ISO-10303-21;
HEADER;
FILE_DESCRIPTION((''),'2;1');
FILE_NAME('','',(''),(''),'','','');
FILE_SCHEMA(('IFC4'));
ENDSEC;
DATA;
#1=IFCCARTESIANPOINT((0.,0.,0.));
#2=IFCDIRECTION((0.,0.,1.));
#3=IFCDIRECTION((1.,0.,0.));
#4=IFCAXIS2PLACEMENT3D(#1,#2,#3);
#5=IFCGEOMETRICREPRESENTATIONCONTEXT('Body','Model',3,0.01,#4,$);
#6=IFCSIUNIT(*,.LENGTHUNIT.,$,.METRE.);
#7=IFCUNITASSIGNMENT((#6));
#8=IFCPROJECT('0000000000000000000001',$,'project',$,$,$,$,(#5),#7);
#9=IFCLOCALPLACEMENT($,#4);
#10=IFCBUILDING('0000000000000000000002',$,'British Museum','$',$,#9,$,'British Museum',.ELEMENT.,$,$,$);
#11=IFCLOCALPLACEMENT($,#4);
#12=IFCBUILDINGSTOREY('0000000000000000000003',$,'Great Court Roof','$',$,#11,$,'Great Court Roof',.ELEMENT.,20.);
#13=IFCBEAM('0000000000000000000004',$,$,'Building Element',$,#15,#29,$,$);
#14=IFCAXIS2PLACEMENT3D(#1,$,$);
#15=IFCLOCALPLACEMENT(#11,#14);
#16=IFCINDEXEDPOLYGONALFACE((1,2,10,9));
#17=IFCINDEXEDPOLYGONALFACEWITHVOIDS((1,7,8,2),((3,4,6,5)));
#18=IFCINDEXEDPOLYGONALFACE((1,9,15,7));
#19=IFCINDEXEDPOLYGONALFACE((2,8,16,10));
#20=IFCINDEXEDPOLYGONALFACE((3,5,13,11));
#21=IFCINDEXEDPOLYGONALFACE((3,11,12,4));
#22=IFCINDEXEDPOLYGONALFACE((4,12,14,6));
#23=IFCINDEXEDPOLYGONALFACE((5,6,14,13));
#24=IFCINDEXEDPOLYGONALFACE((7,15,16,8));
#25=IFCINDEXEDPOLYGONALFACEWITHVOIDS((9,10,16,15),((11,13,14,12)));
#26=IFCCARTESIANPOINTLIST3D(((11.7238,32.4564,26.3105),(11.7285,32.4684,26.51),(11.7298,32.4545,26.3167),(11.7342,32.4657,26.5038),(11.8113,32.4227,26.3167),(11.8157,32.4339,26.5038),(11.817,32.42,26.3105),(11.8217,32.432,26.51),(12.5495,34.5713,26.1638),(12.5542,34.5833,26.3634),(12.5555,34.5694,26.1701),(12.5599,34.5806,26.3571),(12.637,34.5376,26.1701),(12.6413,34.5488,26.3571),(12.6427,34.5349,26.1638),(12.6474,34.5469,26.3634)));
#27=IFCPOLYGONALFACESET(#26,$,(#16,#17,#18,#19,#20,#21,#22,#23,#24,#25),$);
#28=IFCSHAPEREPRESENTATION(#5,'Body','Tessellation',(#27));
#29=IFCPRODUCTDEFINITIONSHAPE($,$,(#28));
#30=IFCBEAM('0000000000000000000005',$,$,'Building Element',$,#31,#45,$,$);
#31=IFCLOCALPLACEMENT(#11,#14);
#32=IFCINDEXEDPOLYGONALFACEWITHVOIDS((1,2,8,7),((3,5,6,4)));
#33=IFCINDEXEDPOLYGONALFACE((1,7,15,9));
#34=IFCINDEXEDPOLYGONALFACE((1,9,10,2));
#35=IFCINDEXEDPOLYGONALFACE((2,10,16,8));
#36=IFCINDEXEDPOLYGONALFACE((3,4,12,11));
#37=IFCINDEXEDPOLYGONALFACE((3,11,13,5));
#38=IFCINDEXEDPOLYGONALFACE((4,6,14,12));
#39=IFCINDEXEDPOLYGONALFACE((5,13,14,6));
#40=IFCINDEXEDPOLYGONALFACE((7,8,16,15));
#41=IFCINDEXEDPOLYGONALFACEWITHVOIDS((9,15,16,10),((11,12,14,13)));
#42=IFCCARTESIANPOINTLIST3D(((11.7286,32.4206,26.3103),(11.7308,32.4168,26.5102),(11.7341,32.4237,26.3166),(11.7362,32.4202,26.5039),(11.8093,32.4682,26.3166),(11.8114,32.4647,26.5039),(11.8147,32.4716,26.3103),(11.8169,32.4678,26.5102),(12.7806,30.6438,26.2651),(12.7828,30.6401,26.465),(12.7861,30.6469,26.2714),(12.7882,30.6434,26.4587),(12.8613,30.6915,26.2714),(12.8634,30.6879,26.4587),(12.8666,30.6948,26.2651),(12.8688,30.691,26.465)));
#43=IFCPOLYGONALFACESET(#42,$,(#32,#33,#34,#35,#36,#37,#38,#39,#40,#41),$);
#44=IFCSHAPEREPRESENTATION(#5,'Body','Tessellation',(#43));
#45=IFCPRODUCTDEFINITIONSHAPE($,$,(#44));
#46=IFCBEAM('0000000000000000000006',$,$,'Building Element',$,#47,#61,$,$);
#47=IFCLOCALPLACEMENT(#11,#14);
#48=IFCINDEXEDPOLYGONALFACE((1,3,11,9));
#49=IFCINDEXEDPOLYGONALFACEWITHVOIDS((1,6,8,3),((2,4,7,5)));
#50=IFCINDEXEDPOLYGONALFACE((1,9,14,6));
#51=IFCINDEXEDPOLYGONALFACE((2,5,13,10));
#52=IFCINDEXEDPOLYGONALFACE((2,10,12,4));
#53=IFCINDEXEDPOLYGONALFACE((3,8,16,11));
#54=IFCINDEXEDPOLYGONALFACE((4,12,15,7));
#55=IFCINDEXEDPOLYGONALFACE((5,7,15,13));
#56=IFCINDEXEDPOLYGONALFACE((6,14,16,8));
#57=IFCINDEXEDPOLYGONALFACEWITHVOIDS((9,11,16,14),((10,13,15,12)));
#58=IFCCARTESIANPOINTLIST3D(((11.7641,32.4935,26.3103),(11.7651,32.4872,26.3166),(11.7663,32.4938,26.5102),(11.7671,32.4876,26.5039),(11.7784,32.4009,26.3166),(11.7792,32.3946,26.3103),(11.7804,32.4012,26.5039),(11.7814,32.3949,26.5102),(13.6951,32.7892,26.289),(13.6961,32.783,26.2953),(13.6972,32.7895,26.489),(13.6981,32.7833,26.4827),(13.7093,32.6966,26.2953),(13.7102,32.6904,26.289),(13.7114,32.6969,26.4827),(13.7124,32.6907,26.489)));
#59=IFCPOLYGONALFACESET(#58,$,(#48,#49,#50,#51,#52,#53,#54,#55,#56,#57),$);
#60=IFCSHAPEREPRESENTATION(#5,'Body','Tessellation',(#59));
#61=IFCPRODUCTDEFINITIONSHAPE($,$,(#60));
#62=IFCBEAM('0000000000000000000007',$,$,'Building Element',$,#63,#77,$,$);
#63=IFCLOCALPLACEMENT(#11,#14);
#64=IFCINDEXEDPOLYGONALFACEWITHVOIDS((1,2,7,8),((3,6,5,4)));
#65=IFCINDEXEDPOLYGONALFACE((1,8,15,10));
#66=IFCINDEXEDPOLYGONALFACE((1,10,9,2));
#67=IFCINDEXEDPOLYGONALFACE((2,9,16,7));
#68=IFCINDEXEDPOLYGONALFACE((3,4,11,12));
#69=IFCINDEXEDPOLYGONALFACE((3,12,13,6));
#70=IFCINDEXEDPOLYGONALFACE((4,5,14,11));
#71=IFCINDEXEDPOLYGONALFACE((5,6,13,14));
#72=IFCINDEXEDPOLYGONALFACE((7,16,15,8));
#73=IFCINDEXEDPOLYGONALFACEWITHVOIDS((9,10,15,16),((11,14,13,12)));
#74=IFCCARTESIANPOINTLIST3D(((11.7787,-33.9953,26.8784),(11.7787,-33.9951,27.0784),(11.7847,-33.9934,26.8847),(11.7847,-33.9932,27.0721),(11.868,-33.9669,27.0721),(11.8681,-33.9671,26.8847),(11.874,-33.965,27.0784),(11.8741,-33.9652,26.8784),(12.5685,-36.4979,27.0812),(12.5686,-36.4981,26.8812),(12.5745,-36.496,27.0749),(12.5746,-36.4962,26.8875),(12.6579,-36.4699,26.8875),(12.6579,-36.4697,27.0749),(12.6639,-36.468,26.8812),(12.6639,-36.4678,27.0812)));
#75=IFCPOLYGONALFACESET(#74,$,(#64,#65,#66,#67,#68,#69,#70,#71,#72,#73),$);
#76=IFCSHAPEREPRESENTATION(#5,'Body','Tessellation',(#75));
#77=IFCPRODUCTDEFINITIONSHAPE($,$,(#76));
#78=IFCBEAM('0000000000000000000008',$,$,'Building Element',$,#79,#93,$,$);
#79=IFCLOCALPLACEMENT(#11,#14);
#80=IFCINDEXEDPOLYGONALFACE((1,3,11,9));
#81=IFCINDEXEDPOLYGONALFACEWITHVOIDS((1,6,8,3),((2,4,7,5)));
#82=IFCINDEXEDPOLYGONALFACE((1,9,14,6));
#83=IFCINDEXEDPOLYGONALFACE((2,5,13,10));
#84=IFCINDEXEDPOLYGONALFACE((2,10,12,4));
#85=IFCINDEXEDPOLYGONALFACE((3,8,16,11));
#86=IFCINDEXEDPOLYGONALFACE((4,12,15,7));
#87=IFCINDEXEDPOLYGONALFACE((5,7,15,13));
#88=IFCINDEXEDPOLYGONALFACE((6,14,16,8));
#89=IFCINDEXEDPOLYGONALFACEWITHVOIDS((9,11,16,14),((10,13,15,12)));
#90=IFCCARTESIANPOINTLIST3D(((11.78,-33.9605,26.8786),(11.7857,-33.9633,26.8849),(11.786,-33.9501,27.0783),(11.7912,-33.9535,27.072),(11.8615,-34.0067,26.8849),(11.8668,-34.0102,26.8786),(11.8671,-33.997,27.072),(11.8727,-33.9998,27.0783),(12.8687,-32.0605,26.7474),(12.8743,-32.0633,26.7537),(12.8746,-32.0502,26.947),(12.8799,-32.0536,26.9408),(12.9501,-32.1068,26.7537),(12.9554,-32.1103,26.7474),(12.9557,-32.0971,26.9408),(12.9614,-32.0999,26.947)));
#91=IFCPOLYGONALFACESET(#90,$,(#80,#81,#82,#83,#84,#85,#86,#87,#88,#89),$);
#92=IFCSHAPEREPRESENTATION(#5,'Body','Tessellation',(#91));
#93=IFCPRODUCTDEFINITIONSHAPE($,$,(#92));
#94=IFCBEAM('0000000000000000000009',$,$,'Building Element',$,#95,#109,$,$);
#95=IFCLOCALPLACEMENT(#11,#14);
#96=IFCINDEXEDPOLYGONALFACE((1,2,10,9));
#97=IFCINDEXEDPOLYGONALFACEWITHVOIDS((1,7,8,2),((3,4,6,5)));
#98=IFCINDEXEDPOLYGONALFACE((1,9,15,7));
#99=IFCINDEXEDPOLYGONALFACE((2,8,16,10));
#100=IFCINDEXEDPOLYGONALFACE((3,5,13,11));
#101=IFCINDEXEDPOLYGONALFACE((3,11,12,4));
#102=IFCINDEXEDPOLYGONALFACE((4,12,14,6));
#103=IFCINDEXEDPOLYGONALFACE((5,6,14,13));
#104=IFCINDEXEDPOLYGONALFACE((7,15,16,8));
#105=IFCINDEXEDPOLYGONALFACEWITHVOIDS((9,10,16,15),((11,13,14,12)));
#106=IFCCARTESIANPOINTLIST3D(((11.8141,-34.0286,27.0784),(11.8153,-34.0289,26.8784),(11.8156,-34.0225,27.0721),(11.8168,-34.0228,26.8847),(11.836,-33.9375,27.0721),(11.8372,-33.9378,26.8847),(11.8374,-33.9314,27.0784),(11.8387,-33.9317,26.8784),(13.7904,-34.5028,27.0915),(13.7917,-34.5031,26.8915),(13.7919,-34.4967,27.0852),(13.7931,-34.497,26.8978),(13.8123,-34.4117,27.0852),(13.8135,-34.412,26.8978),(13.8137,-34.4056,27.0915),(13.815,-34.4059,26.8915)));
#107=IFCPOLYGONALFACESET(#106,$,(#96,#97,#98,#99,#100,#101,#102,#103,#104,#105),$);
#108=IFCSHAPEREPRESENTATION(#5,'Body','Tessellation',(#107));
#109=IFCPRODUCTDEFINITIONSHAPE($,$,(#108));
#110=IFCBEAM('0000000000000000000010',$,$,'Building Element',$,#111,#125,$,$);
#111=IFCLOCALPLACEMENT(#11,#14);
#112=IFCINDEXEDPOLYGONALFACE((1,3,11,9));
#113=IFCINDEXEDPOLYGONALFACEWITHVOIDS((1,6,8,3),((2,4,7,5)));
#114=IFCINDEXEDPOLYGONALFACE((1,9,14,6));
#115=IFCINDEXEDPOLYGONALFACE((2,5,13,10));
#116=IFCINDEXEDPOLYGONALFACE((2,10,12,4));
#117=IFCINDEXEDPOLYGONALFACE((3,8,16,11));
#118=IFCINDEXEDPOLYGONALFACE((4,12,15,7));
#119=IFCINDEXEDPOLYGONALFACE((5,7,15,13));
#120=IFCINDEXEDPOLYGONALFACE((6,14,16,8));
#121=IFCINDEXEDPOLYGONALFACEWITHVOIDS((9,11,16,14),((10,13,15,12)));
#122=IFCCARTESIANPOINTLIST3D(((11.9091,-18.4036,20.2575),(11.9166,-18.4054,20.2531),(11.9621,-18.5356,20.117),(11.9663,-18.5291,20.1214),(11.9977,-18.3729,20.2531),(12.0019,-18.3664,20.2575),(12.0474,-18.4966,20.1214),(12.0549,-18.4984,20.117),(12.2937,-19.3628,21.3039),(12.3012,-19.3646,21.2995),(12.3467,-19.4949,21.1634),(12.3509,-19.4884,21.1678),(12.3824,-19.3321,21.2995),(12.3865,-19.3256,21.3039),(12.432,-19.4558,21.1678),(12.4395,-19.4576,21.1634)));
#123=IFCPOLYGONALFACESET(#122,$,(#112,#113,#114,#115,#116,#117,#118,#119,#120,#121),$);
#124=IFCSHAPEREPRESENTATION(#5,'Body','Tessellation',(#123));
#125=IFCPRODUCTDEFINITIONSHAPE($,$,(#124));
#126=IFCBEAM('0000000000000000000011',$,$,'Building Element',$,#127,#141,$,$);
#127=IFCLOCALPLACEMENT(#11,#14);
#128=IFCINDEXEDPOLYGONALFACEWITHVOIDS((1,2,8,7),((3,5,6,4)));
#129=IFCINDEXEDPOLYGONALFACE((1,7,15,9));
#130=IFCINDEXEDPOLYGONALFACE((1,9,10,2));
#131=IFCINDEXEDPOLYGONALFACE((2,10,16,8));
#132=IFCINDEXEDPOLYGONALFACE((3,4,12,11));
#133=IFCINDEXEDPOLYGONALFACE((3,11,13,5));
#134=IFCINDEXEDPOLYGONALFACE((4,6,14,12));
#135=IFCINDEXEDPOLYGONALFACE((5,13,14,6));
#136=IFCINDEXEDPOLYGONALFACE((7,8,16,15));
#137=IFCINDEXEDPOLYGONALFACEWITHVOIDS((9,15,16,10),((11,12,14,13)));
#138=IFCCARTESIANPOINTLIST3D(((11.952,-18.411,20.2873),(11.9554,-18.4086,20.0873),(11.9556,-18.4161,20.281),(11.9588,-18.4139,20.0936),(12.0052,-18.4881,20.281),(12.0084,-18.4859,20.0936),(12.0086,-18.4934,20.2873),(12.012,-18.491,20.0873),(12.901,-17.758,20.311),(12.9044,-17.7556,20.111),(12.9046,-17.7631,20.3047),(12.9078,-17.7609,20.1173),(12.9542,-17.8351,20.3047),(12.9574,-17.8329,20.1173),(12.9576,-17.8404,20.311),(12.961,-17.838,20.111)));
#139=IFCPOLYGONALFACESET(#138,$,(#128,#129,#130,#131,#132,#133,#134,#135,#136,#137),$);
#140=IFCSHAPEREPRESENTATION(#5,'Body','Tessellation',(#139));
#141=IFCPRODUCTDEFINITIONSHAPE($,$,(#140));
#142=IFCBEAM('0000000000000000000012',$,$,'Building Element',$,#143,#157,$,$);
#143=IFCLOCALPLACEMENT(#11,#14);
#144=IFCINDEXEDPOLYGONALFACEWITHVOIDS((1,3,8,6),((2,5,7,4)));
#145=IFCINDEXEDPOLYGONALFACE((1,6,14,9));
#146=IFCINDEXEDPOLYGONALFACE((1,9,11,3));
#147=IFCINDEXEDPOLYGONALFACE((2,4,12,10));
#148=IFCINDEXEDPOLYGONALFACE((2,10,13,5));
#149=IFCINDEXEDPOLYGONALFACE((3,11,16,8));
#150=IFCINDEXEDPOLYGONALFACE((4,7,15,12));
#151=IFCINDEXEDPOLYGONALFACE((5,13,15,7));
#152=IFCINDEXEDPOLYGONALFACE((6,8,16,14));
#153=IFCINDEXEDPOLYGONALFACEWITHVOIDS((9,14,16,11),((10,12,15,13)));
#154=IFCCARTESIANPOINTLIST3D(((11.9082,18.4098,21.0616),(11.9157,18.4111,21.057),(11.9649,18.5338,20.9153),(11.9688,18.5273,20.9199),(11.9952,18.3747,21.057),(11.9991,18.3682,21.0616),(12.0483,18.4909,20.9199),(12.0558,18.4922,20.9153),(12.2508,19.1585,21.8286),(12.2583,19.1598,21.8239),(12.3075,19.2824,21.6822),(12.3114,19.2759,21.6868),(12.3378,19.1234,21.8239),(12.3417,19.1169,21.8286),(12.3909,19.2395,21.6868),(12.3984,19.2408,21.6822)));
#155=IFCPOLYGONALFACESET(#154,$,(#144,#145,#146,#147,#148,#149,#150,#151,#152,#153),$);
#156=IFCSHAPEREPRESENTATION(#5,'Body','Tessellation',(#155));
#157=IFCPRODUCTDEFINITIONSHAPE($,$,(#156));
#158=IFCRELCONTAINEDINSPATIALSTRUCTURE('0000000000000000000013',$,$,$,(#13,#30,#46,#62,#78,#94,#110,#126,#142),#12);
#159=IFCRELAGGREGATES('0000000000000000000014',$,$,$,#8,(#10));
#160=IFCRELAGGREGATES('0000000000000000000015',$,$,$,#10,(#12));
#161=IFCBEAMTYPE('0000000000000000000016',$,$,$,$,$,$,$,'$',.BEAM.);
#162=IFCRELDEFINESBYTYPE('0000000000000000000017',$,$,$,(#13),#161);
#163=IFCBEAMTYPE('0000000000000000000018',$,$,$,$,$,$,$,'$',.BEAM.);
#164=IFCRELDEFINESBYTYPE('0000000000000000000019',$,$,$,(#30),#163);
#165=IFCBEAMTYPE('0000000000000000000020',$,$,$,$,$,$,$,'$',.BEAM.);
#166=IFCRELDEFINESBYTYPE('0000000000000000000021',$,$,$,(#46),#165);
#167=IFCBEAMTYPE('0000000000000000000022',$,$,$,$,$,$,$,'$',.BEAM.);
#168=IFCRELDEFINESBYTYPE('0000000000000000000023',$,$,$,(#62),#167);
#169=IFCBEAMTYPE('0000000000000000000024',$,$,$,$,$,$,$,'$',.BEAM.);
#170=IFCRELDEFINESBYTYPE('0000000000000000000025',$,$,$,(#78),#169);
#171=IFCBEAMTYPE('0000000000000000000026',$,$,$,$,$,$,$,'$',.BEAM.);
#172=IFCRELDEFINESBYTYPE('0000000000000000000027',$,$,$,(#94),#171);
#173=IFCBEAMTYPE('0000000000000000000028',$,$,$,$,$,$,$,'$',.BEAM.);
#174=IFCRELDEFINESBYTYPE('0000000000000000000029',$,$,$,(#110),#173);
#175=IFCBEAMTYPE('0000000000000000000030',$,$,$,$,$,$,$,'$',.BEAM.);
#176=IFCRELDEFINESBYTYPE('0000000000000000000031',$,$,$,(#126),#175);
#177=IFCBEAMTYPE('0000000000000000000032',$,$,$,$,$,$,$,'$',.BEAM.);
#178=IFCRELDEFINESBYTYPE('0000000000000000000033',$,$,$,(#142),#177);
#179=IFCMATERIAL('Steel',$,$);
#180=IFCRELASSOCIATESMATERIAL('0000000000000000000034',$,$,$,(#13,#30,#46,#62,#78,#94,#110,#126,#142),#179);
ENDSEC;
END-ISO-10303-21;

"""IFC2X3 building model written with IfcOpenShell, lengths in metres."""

from ifc_helpers import new_model, si_unit, frame, origin_with_axes, origin_2d, place, context, project, spatial, hollow_rectangle, extrude, material, type_object, element, save


model = new_model("IFC2X3")

# Units and contexts
model_context = context("Model", 3, precision=0.01, world=origin_with_axes(), identifier="Body")
ifc_project = project(units=[si_unit("LENGTHUNIT", "METRE")], contexts=[model_context])

# Building, storey
building_placement = place(None, origin_with_axes())
building = spatial("IfcBuilding", under=ifc_project, at=building_placement, Name="British Museum", Description="$", LongName="British Museum", CompositionType="ELEMENT")
storey_placement = place(None, origin_with_axes())
storey = spatial("IfcBuildingStorey", under=building, at=storey_placement, Name="Great Court Roof", Description="$", LongName="Great Court Roof", CompositionType="ELEMENT", Elevation=20.0)

# Beams
ifc_material = material(Name="Steel")
beam_type_1 = type_object("IfcBeamType", ElementType="$", PredefinedType="BEAM")
beam_1_placement = place(None, origin_with_axes())
element("IfcBeam", 1, at=beam_1_placement, inside=storey, type_object=beam_type_1, material=ifc_material, Description="Building Element", context=model_context, shape_type="SweptSolid", body=[
    extrude(hollow_rectangle(XDim=0.1, YDim=0.2, WallThickness=0.0063, InnerFilletRadius=-0.0063, OuterFilletRadius=0.0, at=origin_2d()), frame((11.7728, 32.4442, 26.4103), z_axis=(0.362924, 0.929586, -0.06447), x_axis=(-0.931524, 0.363681, 0.0)), (0.0, 0.0, 1.0), 2.2751),
])
beam_type_2 = type_object("IfcBeamType", ElementType="$", PredefinedType="BEAM")
beam_2_placement = place(None, origin_with_axes())
element("IfcBeam", 2, at=beam_2_placement, inside=storey, type_object=beam_type_2, material=ifc_material, Description="Building Element", context=model_context, shape_type="SweptSolid", body=[
    extrude(hollow_rectangle(XDim=0.1, YDim=0.2, WallThickness=0.0063, InnerFilletRadius=-0.0063, OuterFilletRadius=0.0, at=origin_2d()), frame((11.7728, 32.4442, 26.4103), z_axis=(0.509341, -0.860287, -0.021888), x_axis=(0.860493, 0.509463, 0.0)), (0.0, 0.0, 1.0), 2.0653),
])
beam_type_3 = type_object("IfcBeamType", ElementType="$", PredefinedType="BEAM")
beam_3_placement = place(None, origin_with_axes())
element("IfcBeam", 3, at=beam_3_placement, inside=storey, type_object=beam_type_3, material=ifc_material, Description="Building Element", context=model_context, shape_type="SweptSolid", body=[
    extrude(hollow_rectangle(XDim=0.1, YDim=0.2, WallThickness=0.0063, InnerFilletRadius=-0.0063, OuterFilletRadius=0.0, at=origin_2d()), frame((11.7728, 32.4442, 26.4103), z_axis=(0.988416, 0.151381, -0.010862), x_axis=(-0.15139, 0.988474, 0.0)), (0.0, 0.0, 1.0), 1.9536),
])
beam_type_4 = type_object("IfcBeamType", ElementType="$", PredefinedType="BEAM")
beam_4_placement = place(None, origin_with_axes())
element("IfcBeam", 4, at=beam_4_placement, inside=storey, type_object=beam_type_4, material=ifc_material, Description="Building Element", context=model_context, shape_type="SweptSolid", body=[
    extrude(hollow_rectangle(XDim=0.1, YDim=0.2, WallThickness=0.0063, InnerFilletRadius=-0.0063, OuterFilletRadius=0.0, at=origin_2d()), frame((11.8264, -33.9801, 26.9784), z_axis=(0.300953, -0.953638, 0.001045), x_axis=(0.953639, 0.300954, 0.0)), (0.0, 0.0, 1.0), 2.6245),
])
beam_type_5 = type_object("IfcBeamType", ElementType="$", PredefinedType="BEAM")
beam_5_placement = place(None, origin_with_axes())
element("IfcBeam", 5, at=beam_5_placement, inside=storey, type_object=beam_type_5, material=ifc_material, Description="Building Element", context=model_context, shape_type="SweptSolid", body=[
    extrude(hollow_rectangle(XDim=0.1, YDim=0.2, WallThickness=0.0063, InnerFilletRadius=-0.0063, OuterFilletRadius=0.0, at=origin_2d()), frame((11.8264, -33.9801, 26.9784), z_axis=(0.496268, 0.866106, -0.059819), x_axis=(-0.86766, 0.497158, 0.0)), (0.0, 0.0, 1.0), 2.1936),
])
beam_type_6 = type_object("IfcBeamType", ElementType="$", PredefinedType="BEAM")
beam_6_placement = place(None, origin_with_axes())
element("IfcBeam", 6, at=beam_6_placement, inside=storey, type_object=beam_type_6, material=ifc_material, Description="Building Element", context=model_context, shape_type="SweptSolid", body=[
    extrude(hollow_rectangle(XDim=0.1, YDim=0.2, WallThickness=0.0063, InnerFilletRadius=-0.0063, OuterFilletRadius=0.0, at=origin_2d()), frame((11.8264, -33.9801, 26.9784), z_axis=(0.972378, -0.233322, 0.006427), x_axis=(0.233327, 0.972398, 0.0)), (0.0, 0.0, 1.0), 2.0325),
])
beam_type_7 = type_object("IfcBeamType", ElementType="$", PredefinedType="BEAM")
beam_7_placement = place(None, origin_with_axes())
element("IfcBeam", 7, at=beam_7_placement, inside=storey, type_object=beam_type_7, material=ifc_material, Description="Building Element", context=model_context, shape_type="SweptSolid", body=[
    extrude(hollow_rectangle(XDim=0.1, YDim=0.2, WallThickness=0.0063, InnerFilletRadius=-0.0063, OuterFilletRadius=0.0, at=origin_2d()), frame((11.982, -18.451, 20.1873), z_axis=(0.261521, -0.652218, 0.71149), x_axis=(0.928165, 0.372168, 0.0)), (0.0, 0.0, 1.0), 1.4707),
])
beam_type_8 = type_object("IfcBeamType", ElementType="$", PredefinedType="BEAM")
beam_8_placement = place(None, origin_with_axes())
element("IfcBeam", 8, at=beam_8_placement, inside=storey, type_object=beam_type_8, material=ifc_material, Description="Building Element", context=model_context, shape_type="SweptSolid", body=[
    extrude(hollow_rectangle(XDim=0.1, YDim=0.2, WallThickness=0.0063, InnerFilletRadius=-0.0063, OuterFilletRadius=0.0, at=origin_2d()), frame((11.982, -18.451, 20.1873), z_axis=(0.823639, 0.56674, 0.020608), x_axis=(-0.56686, 0.823814, 0.0)), (0.0, 0.0, 1.0), 1.1522),
])
beam_type_9 = type_object("IfcBeamType", ElementType="$", PredefinedType="BEAM")
beam_9_placement = place(None, origin_with_axes())
element("IfcBeam", 9, at=beam_9_placement, inside=storey, type_object=beam_type_9, material=ifc_material, Description="Building Element", context=model_context, shape_type="SweptSolid", body=[
    extrude(hollow_rectangle(XDim=0.1, YDim=0.2, WallThickness=0.0063, InnerFilletRadius=-0.0063, OuterFilletRadius=0.0, at=origin_2d()), frame((11.982, 18.451, 20.9884), z_axis=(0.304474, 0.665351, 0.681618), x_axis=(-0.909312, 0.416114, 0.0)), (0.0, 0.0, 1.0), 1.1252),
])

save(model, "model.ifc")
